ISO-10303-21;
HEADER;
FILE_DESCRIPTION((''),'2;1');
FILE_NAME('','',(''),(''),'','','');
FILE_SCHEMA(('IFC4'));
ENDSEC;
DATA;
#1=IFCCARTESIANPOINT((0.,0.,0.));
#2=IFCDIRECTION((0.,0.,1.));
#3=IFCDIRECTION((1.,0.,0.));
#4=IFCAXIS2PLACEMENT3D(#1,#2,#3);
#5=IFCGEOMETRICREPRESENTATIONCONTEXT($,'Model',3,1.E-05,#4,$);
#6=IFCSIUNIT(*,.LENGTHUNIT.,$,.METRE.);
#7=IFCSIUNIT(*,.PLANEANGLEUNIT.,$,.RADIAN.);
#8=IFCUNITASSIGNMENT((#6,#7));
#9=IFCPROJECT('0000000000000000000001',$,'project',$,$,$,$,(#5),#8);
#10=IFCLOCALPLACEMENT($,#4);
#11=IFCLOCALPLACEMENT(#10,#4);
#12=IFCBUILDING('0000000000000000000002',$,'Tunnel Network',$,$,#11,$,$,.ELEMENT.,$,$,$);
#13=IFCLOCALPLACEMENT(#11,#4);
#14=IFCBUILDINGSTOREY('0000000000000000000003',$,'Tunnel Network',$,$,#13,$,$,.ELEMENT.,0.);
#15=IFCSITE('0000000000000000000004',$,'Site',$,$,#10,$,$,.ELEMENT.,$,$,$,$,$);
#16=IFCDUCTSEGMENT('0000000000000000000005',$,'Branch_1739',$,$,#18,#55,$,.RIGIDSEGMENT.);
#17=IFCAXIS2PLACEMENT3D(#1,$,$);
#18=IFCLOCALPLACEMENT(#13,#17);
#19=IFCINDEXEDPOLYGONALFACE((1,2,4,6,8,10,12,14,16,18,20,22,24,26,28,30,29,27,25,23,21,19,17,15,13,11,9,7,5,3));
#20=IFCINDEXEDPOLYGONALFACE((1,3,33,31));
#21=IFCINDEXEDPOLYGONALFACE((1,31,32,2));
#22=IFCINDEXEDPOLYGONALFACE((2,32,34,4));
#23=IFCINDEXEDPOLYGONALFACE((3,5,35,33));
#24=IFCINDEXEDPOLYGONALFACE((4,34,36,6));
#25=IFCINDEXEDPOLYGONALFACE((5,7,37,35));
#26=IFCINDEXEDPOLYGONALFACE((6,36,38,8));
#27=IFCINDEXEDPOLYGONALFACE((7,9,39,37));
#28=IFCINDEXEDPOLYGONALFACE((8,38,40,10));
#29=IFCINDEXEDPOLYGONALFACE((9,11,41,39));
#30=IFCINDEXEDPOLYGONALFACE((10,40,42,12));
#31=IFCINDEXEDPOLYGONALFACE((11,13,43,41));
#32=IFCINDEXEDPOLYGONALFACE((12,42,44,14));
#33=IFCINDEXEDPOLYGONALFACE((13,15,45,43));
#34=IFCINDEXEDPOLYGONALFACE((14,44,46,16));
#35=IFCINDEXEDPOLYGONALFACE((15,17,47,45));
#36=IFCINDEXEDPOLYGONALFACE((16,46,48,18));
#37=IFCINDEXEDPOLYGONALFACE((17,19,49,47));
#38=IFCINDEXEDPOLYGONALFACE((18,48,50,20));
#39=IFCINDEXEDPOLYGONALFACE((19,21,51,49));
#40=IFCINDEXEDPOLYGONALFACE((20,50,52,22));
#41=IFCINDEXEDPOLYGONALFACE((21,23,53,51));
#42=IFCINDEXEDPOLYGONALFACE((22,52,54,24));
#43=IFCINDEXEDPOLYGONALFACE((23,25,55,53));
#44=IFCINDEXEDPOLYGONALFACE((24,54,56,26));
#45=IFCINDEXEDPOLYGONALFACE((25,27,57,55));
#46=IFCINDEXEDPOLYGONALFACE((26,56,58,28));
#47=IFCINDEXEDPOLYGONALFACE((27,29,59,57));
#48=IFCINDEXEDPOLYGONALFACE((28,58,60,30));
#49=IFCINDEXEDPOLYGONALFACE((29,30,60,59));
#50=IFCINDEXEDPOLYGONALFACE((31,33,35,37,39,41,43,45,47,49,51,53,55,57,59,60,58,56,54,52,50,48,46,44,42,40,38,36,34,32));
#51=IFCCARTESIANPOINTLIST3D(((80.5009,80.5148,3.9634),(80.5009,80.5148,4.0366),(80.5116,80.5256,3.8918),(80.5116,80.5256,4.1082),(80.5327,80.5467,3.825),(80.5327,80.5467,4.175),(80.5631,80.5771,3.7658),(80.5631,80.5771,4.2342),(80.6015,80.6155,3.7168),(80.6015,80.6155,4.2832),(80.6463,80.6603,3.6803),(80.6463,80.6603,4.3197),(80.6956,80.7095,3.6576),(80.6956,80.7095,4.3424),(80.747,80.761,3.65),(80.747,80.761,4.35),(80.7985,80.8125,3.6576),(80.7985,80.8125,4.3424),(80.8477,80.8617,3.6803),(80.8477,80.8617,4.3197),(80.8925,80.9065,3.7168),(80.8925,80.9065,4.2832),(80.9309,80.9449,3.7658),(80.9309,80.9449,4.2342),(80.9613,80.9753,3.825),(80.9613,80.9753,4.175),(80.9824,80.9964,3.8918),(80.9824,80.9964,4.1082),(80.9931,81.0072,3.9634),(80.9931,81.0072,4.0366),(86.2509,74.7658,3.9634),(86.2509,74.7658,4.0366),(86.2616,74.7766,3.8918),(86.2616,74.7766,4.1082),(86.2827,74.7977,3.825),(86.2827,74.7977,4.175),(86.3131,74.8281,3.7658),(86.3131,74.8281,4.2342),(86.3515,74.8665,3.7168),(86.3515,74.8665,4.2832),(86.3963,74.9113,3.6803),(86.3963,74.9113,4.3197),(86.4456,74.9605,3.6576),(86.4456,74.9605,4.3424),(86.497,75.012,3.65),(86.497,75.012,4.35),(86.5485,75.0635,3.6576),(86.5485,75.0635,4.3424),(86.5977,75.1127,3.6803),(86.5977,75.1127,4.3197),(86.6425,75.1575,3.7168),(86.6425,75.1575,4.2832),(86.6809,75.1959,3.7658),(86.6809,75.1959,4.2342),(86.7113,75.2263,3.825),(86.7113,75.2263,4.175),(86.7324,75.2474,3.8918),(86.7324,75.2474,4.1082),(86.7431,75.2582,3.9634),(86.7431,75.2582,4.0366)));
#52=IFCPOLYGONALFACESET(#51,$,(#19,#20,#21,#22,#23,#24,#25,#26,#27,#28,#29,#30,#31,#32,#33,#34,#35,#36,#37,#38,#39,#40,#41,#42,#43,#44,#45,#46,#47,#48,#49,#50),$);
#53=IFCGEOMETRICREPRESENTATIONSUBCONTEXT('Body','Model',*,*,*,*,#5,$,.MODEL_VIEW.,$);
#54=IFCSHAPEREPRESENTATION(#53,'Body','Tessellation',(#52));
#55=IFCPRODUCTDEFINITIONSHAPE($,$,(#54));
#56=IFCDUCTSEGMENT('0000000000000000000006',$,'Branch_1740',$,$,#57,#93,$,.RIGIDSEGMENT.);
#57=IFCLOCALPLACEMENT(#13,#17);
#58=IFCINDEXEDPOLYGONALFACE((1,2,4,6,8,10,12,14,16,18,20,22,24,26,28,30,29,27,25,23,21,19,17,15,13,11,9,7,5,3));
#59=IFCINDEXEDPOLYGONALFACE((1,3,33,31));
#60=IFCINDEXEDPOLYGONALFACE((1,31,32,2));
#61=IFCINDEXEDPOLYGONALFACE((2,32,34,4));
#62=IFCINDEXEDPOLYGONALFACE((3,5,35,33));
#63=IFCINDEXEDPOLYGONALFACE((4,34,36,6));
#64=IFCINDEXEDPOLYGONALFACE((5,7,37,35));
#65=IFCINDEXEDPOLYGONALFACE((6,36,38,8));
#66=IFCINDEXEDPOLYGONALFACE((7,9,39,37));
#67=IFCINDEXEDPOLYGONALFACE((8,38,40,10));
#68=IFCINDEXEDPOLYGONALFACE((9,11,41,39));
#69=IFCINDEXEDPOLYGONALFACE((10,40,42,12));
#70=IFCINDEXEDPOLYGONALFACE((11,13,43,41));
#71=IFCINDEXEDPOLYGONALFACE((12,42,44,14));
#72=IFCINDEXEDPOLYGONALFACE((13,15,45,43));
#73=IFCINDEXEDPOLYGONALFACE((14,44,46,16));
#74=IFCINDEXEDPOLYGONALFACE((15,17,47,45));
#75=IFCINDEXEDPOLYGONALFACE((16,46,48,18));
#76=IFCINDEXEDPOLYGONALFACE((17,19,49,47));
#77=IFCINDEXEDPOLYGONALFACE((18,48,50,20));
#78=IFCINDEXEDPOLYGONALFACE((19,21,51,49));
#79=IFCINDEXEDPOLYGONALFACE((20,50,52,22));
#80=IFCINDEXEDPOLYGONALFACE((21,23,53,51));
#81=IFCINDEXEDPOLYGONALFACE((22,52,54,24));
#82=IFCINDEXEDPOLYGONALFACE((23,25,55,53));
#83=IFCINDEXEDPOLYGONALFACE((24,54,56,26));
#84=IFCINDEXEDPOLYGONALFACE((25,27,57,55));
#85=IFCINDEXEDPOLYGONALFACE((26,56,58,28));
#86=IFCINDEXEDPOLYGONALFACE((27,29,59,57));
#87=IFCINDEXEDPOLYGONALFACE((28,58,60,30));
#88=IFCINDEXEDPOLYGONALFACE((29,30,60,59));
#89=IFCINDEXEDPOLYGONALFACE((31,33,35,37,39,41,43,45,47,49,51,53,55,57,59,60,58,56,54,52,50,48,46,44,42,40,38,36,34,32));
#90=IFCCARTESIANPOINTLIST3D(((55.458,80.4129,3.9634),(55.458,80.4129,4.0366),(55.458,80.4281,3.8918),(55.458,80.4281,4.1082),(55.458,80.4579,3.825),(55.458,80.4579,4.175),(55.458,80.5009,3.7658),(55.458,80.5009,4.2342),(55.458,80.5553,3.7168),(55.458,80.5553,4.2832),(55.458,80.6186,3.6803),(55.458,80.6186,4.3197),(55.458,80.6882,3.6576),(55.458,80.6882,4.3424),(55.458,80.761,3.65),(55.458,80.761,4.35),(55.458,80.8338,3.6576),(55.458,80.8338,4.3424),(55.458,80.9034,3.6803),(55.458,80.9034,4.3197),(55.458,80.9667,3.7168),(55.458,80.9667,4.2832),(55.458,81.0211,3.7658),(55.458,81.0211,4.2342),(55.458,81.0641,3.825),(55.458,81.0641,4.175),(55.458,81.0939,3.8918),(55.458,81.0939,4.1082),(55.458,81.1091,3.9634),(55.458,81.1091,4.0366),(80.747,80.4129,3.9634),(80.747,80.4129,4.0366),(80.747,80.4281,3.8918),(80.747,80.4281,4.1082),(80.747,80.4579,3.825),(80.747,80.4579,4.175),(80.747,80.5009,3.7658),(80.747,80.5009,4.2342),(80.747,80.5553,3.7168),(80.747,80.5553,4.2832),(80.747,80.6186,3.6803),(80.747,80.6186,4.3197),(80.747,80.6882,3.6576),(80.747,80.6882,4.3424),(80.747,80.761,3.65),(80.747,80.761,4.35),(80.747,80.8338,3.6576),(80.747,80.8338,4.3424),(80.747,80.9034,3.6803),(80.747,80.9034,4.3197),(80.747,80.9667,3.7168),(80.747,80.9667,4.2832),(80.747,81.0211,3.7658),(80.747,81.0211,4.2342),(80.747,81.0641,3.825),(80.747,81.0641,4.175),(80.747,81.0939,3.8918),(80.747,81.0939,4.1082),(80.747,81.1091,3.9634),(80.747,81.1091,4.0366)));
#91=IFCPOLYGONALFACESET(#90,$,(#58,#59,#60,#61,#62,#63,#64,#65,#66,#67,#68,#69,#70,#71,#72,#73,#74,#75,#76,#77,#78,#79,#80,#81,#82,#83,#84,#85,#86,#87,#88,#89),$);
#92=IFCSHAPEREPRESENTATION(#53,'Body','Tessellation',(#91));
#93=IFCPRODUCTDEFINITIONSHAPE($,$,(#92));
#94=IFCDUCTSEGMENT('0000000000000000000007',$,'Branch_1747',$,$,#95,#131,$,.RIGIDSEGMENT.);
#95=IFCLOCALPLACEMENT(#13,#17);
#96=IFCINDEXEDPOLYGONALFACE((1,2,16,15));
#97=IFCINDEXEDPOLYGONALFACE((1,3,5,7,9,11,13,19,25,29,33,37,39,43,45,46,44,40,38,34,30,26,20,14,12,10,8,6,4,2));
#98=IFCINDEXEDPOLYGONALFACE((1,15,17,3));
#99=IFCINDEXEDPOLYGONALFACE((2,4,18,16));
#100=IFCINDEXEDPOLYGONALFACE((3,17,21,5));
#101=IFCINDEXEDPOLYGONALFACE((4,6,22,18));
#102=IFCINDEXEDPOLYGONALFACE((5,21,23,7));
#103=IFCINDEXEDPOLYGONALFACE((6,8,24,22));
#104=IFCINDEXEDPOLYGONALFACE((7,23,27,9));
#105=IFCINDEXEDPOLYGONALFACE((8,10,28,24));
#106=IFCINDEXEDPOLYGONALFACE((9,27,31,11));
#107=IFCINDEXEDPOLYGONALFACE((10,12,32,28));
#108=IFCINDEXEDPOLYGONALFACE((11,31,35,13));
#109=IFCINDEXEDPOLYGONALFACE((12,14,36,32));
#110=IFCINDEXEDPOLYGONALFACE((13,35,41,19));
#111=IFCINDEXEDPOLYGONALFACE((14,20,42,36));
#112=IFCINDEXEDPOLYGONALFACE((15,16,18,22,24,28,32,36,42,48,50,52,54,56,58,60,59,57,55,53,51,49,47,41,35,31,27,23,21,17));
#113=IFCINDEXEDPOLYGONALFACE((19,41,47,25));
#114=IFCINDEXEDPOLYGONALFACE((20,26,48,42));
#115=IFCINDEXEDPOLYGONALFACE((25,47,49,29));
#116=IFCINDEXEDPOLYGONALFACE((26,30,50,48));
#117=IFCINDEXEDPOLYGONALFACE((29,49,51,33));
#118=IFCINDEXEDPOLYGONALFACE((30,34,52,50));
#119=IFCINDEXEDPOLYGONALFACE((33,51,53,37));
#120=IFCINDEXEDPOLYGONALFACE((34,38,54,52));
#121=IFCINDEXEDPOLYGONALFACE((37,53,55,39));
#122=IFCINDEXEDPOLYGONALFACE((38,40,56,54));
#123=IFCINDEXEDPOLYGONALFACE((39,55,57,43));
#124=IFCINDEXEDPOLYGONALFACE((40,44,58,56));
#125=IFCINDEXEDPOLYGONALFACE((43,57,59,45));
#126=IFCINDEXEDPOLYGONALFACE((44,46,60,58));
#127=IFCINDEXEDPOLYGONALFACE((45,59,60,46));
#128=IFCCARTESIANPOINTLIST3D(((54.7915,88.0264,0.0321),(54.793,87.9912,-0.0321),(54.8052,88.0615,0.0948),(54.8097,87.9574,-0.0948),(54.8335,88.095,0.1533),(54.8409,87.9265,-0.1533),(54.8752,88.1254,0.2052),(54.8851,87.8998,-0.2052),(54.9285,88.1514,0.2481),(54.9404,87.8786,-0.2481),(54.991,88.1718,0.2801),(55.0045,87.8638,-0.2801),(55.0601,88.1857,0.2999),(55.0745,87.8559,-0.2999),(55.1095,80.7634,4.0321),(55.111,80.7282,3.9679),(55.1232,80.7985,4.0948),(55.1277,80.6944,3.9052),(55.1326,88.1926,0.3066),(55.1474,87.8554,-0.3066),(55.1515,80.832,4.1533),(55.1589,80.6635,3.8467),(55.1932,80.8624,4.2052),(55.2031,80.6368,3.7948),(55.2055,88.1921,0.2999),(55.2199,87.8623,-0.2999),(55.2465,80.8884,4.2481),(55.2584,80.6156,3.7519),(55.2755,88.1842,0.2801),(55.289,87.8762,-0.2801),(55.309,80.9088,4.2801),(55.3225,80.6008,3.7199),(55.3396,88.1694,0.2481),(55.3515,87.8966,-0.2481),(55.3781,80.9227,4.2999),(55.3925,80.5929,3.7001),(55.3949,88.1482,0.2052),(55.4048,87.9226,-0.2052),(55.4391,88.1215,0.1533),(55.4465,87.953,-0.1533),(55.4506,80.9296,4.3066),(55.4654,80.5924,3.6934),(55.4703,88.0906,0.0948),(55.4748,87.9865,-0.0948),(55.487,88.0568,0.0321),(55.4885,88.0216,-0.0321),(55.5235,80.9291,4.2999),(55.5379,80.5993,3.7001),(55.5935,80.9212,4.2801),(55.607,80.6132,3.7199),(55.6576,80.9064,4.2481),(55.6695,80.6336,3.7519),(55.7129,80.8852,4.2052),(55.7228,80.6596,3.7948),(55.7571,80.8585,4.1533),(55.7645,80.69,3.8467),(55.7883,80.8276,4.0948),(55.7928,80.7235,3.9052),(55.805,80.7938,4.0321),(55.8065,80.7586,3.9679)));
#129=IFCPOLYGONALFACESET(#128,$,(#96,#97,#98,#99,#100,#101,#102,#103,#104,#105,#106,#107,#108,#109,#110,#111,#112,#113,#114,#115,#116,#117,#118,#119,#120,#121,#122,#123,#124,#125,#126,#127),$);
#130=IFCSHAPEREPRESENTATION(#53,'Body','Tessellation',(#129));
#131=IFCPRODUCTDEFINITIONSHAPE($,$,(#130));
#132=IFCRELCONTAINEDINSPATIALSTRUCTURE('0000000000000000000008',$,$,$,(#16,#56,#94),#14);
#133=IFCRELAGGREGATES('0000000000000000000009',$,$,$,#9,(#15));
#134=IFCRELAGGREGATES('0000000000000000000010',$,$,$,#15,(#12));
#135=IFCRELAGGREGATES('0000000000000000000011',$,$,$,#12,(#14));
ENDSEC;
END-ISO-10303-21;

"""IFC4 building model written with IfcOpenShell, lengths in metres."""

from ifc_helpers import new_model, si_unit, frame, origin_with_axes, origin_2d_with_axis, place, context, subcontext, project, spatial, circle, extrude, element, save


model = new_model("IFC4")

# Units and contexts
model_context = context("Model", 3, precision=1e-05, world=origin_with_axes())
body_context = subcontext(model_context, "Body", "Model", "MODEL_VIEW")
ifc_project = project(units=[si_unit("LENGTHUNIT", "METRE"), si_unit("PLANEANGLEUNIT", "RADIAN")], contexts=[model_context])

# Site, building, storey
site_placement = place(None, origin_with_axes())
site = spatial("IfcSite", under=ifc_project, at=site_placement, Name="Site", CompositionType="ELEMENT")
building_placement = place(site_placement, origin_with_axes())
building = spatial("IfcBuilding", under=site, at=building_placement, Name="Tunnel Network", CompositionType="ELEMENT")
storey_placement = place(building_placement, origin_with_axes())
storey = spatial("IfcBuildingStorey", under=building, at=storey_placement, Name="Tunnel Network", CompositionType="ELEMENT", Elevation=0.0)

# Duct segments
duct_segment_1_placement = place(storey_placement, frame((86.497, 75.012, 4.0), z_axis=(-0.707168, 0.707045, 0.0), x_axis=(0.0, 0.0, 1.0)))
element("IfcDuctSegment", 1, at=duct_segment_1_placement, inside=storey, Name="Branch_1739", PredefinedType="RIGIDSEGMENT", context=body_context, shape_type="SweptSolid", body=[
    extrude(circle(Radius=0.35, at=origin_2d_with_axis()), origin_with_axes(), (0.0, 0.0, 1.0), 8.131),
])
duct_segment_2_placement = place(storey_placement, frame((80.747, 80.761, 4.0), z_axis=(-1.0, 0.0, 0.0), x_axis=(0.0, 0.0, 1.0)))
element("IfcDuctSegment", 2, at=duct_segment_2_placement, inside=storey, Name="Branch_1740", PredefinedType="RIGIDSEGMENT", context=body_context, shape_type="SweptSolid", body=[
    extrude(circle(Radius=0.35, at=origin_2d_with_axis()), origin_with_axes(), (0.0, 0.0, 1.0), 25.289),
])
duct_segment_3_placement = place(storey_placement, frame((55.458, 80.761, 4.0), z_axis=(-0.038324, 0.8753, -0.48206), x_axis=(-0.021086, 0.481598, 0.876138)))
element("IfcDuctSegment", 3, at=duct_segment_3_placement, inside=storey, Name="Branch_1747", PredefinedType="RIGIDSEGMENT", context=body_context, shape_type="SweptSolid", body=[
    extrude(circle(Radius=0.35, at=origin_2d_with_axis()), origin_with_axes(), (0.0, 0.0, 1.0), 8.2977),
])

save(model, "model.ifc")
